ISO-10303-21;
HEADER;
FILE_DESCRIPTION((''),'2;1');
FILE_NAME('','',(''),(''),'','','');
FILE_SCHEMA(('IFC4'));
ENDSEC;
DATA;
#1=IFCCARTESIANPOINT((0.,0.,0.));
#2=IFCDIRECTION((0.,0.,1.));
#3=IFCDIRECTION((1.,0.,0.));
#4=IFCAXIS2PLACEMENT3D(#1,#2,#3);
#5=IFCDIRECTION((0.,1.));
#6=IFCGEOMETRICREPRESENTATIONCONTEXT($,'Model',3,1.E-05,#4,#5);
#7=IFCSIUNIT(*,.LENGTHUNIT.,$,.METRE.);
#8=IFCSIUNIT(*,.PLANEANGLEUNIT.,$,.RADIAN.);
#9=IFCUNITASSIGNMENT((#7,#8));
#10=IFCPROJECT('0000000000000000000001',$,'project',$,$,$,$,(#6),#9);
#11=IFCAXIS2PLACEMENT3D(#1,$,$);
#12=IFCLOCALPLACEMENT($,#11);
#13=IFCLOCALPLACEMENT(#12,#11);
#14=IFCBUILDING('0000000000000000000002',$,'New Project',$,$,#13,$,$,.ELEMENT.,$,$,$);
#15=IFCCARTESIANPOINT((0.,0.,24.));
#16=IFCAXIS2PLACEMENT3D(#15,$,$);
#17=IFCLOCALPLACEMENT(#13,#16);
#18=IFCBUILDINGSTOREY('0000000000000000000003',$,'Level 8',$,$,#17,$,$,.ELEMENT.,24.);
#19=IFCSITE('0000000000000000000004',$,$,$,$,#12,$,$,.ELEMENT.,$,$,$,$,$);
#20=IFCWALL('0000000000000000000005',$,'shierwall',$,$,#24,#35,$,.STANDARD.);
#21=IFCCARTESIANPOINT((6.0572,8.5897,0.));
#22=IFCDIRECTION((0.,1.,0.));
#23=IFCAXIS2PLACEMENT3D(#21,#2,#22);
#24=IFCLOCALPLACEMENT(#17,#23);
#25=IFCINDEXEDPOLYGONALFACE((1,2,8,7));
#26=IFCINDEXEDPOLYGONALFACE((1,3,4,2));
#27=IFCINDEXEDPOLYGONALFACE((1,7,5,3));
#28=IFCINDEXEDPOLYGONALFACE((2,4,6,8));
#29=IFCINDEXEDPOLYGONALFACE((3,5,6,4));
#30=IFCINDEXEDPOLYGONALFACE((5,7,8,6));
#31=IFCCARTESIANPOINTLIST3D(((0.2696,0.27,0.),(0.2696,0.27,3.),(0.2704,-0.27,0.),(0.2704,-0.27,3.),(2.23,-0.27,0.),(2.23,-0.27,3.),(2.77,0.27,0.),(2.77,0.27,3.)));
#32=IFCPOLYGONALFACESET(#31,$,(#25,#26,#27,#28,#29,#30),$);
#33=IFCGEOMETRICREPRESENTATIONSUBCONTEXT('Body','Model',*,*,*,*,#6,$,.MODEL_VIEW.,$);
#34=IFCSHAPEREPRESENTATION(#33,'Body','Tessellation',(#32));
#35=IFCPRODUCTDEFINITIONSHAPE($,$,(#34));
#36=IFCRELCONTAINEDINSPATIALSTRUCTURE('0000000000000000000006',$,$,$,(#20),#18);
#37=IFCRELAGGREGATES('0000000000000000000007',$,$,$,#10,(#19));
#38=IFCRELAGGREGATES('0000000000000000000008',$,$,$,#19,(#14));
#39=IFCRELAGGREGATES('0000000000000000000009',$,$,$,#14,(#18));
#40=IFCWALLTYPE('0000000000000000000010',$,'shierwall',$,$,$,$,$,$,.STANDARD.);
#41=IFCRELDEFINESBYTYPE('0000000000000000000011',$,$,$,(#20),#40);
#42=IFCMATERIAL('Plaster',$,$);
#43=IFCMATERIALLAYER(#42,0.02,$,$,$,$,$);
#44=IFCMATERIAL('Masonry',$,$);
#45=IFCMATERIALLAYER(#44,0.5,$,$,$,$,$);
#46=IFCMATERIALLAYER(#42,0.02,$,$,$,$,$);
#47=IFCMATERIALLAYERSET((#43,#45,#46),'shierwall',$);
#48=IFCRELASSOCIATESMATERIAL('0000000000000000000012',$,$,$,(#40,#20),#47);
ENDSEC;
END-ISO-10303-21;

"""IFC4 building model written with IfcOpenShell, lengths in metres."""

from ifc_helpers import new_model, si_unit, direction, frame, origin, origin_with_axes, place, context, subcontext, project, spatial, polyline, outline, extrude, material, layer, layer_set, layer_usage, type_object, element, save


model = new_model("IFC4")

# Units and contexts
model_context = context("Model", 3, precision=1e-05, world=origin_with_axes(), true_north=direction((0.0, 1.0)))
body_context = subcontext(model_context, "Body", "Model", "MODEL_VIEW")
ifc_project = project(units=[si_unit("LENGTHUNIT", "METRE"), si_unit("PLANEANGLEUNIT", "RADIAN")], contexts=[model_context])

# Site, building, storey
site_placement = place(None, origin())
site = spatial("IfcSite", under=ifc_project, at=site_placement, CompositionType="ELEMENT")
building_placement = place(site_placement, origin())
building = spatial("IfcBuilding", under=site, at=building_placement, Name="New Project", CompositionType="ELEMENT")
storey_placement = place(building_placement, frame((0.0, 0.0, 24.0)))
storey = spatial("IfcBuildingStorey", under=building, at=storey_placement, Name="Level 8", CompositionType="ELEMENT", Elevation=24.0)

# Shared definitions
ifc_material_1 = material(Name="Plaster")
ifc_material_2 = material(Name="Masonry")

# Shared definitions
ifc_layer_1 = layer(ifc_material_1, 0.02)
ifc_layer_2 = layer(ifc_material_2, 0.5)
ifc_layer_3 = layer(ifc_material_1, 0.02)
ifc_layer_set_1 = layer_set([ifc_layer_1, ifc_layer_2, ifc_layer_3], Name="shierwall")
ifc_layer_usage_1 = layer_usage(ifc_layer_set_1, "AXIS2", "NEGATIVE", 0.27)
wall_type_1 = type_object("IfcWallType", Name="shierwall", PredefinedType="STANDARD", material=ifc_layer_set_1)

# Wall
wall_1_placement = place(storey_placement, frame((6.0572, 8.5897, 0.0), z_axis=(0.0, 0.0, 1.0), x_axis=(0.0, 1.0, 0.0)))
element("IfcWall", 1, at=wall_1_placement, inside=storey, type_object=wall_type_1, material=ifc_layer_usage_1, Name="shierwall", PredefinedType="STANDARD", context=body_context, shape_type="SweptSolid", body=[
    extrude(outline(polyline([(0.2704, -0.27), (2.23, -0.27), (2.77, 0.27), (0.2696, 0.27), (0.2704, -0.27)])), origin(), (0.0, 0.0, 1.0), 3.0),
])

save(model, "model.ifc")
